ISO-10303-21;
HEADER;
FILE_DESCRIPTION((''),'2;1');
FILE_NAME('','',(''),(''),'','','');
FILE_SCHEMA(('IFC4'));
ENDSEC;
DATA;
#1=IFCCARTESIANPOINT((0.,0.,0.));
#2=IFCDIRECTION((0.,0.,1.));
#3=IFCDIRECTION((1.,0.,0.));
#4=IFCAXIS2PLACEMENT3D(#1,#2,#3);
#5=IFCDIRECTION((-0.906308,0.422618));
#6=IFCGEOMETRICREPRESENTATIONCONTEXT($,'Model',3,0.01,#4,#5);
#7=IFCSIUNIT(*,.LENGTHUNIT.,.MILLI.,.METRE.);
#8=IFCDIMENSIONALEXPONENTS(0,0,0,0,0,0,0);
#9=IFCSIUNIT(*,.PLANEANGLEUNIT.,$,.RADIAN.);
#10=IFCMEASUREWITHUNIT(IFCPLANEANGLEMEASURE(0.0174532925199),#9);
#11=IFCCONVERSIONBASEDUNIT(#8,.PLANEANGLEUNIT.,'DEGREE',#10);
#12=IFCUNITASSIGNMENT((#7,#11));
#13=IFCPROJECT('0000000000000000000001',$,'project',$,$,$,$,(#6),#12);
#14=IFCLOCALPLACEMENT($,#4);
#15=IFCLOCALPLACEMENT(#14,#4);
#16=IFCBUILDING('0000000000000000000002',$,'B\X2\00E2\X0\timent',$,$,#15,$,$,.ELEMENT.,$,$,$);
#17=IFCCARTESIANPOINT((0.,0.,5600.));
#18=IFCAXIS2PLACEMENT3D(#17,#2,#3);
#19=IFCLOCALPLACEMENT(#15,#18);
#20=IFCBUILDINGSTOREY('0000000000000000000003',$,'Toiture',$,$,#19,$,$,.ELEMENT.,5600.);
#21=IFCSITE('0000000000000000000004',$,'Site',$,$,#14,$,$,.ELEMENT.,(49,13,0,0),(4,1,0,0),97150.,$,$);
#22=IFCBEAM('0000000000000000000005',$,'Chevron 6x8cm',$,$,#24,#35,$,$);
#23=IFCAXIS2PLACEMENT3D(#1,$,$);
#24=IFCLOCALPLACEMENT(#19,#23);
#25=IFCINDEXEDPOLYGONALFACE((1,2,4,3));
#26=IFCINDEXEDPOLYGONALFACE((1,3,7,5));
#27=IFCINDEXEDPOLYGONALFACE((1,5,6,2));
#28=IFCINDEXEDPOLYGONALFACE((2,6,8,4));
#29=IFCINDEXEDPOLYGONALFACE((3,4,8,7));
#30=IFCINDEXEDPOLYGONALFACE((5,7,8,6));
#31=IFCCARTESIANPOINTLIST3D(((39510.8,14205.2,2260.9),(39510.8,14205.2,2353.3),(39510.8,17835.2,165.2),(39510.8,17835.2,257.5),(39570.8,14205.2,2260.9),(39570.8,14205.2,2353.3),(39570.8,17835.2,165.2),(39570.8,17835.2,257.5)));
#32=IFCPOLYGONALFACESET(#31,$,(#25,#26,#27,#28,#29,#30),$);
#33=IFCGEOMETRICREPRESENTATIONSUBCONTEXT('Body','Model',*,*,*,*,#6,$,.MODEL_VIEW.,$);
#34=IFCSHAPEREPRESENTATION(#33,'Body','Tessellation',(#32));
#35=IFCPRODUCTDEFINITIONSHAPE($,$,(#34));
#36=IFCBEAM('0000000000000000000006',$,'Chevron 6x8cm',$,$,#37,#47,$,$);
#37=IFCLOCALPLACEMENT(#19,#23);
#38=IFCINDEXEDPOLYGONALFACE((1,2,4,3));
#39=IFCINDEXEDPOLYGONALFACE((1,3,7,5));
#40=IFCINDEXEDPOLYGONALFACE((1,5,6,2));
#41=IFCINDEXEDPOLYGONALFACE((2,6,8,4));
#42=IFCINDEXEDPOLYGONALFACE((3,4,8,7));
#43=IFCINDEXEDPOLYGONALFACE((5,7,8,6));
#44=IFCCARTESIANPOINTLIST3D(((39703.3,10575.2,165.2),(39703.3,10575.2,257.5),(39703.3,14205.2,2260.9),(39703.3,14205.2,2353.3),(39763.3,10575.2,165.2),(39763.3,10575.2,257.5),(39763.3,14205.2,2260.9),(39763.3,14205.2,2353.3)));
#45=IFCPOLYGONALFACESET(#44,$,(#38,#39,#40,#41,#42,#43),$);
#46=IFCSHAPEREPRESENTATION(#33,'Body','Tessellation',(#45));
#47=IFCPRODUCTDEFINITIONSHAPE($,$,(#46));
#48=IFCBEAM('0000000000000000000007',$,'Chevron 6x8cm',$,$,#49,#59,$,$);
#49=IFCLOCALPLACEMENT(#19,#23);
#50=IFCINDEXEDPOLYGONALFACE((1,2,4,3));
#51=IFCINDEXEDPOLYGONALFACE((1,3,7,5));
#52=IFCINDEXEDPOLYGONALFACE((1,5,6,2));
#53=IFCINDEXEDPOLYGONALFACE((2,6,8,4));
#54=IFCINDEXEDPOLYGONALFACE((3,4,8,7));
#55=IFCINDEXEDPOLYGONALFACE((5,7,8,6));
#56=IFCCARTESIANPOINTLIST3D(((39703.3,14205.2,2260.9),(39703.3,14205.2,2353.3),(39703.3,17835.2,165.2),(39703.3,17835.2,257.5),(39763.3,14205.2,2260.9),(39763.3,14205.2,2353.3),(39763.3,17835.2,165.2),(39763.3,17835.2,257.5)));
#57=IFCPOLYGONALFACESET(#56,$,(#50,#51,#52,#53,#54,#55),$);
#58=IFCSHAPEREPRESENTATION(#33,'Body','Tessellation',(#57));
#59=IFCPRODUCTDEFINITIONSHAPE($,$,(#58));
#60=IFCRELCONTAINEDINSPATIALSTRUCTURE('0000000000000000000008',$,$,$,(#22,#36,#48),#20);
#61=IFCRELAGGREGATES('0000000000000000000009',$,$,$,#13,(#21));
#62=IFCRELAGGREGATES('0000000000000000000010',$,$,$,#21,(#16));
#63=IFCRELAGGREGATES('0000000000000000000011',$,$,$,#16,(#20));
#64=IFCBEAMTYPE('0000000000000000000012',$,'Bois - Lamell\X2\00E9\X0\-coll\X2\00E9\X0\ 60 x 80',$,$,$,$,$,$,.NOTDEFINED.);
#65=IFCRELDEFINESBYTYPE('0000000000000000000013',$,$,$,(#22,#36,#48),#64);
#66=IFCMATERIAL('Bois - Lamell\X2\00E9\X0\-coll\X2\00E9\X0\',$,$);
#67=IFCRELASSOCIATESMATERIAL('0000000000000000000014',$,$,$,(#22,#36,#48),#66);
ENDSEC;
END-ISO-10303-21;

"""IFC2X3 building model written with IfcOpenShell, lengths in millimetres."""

from ifc_helpers import new_model, entity, si_unit, converted_unit, direction, frame, frame_2d, origin_with_axes, place, context, subcontext, project, spatial, rectangle, extrude, clip, halfspace, material, type_object, element, save


model = new_model("IFC2X3")

# Units and contexts
model_context = context("Model", 3, precision=0.01, world=origin_with_axes(), true_north=direction((-0.906308, 0.422618)))
body_context = subcontext(model_context, "Body", "Model", "MODEL_VIEW")
ifc_project = project(units=[si_unit("LENGTHUNIT", "METRE", prefix="MILLI"), converted_unit("PLANEANGLEUNIT", "DEGREE", entity("IfcPlaneAngleMeasure", 0.0174532925199), si_unit("PLANEANGLEUNIT", "RADIAN"), dimensions=[0, 0, 0, 0, 0, 0, 0])], contexts=[model_context])

# Site, building, storey
site_placement = place(None, origin_with_axes())
site = spatial("IfcSite", under=ifc_project, at=site_placement, Name="Site", CompositionType="ELEMENT", RefLatitude=(49, 13, 0, 0), RefLongitude=(4, 1, 0, 0), RefElevation=97150.0)
building_placement = place(site_placement, origin_with_axes())
building = spatial("IfcBuilding", under=site, at=building_placement, Name="Bâtiment", CompositionType="ELEMENT")
storey_placement = place(building_placement, frame((0.0, 0.0, 5600.0), z_axis=(0.0, 0.0, 1.0), x_axis=(1.0, 0.0, 0.0)))
storey = spatial("IfcBuildingStorey", under=building, at=storey_placement, Name="Toiture", CompositionType="ELEMENT", Elevation=5600.0)

# Beams
ifc_material = material(Name="Bois - Lamellé-collé")
beam_type = type_object("IfcBeamType", Name="Bois - Lamellé-collé 60 x 80", PredefinedType="NOTDEFINED")
for number, where, z_axis, x_axis, name in (
    (1, (39540.8, 17835.2, 257.5), (0.0, 0.0, 1.0), (-1.0, 0.0, 0.0), "Chevron 6x8cm"),
    (2, (39733.3, 10575.2, 257.5), (0.0, 0.0, 1.0), (1.0, 0.0, 0.0), "Chevron 6x8cm"),
    (3, (39733.3, 17835.2, 257.5), (0.0, 0.0, 1.0), (-1.0, 0.0, 0.0), "Chevron 6x8cm"),
):
    element("IfcBeam", number, at=place(storey_placement, frame(where, z_axis=z_axis, x_axis=x_axis)), inside=storey, type_object=beam_type, material=ifc_material, Name=name, context=body_context, shape_type="Clipping", body=[
        clip(clip(extrude(rectangle(XDim=80.0, YDim=60.0, at=frame_2d((-40.0, 0.0), x_axis=(1.0, 0.0))), frame((0.0, -56.6, -32.7), z_axis=(0.0, 0.866025, 0.5), x_axis=(0.0, -0.5, 0.866025)), (0.0, 0.0, 1.0), 4322.2), halfspace(frame((0.0, 0.0, 0.0), z_axis=(0.0, 1.0, 0.0), x_axis=(0.0, 0.0, 1.0)), True)), halfspace(frame((0.0, 3630.0, 0.0), z_axis=(0.0, -1.0, 0.0), x_axis=(0.0, 0.0, -1.0)), True)),
    ])

save(model, "model.ifc")
